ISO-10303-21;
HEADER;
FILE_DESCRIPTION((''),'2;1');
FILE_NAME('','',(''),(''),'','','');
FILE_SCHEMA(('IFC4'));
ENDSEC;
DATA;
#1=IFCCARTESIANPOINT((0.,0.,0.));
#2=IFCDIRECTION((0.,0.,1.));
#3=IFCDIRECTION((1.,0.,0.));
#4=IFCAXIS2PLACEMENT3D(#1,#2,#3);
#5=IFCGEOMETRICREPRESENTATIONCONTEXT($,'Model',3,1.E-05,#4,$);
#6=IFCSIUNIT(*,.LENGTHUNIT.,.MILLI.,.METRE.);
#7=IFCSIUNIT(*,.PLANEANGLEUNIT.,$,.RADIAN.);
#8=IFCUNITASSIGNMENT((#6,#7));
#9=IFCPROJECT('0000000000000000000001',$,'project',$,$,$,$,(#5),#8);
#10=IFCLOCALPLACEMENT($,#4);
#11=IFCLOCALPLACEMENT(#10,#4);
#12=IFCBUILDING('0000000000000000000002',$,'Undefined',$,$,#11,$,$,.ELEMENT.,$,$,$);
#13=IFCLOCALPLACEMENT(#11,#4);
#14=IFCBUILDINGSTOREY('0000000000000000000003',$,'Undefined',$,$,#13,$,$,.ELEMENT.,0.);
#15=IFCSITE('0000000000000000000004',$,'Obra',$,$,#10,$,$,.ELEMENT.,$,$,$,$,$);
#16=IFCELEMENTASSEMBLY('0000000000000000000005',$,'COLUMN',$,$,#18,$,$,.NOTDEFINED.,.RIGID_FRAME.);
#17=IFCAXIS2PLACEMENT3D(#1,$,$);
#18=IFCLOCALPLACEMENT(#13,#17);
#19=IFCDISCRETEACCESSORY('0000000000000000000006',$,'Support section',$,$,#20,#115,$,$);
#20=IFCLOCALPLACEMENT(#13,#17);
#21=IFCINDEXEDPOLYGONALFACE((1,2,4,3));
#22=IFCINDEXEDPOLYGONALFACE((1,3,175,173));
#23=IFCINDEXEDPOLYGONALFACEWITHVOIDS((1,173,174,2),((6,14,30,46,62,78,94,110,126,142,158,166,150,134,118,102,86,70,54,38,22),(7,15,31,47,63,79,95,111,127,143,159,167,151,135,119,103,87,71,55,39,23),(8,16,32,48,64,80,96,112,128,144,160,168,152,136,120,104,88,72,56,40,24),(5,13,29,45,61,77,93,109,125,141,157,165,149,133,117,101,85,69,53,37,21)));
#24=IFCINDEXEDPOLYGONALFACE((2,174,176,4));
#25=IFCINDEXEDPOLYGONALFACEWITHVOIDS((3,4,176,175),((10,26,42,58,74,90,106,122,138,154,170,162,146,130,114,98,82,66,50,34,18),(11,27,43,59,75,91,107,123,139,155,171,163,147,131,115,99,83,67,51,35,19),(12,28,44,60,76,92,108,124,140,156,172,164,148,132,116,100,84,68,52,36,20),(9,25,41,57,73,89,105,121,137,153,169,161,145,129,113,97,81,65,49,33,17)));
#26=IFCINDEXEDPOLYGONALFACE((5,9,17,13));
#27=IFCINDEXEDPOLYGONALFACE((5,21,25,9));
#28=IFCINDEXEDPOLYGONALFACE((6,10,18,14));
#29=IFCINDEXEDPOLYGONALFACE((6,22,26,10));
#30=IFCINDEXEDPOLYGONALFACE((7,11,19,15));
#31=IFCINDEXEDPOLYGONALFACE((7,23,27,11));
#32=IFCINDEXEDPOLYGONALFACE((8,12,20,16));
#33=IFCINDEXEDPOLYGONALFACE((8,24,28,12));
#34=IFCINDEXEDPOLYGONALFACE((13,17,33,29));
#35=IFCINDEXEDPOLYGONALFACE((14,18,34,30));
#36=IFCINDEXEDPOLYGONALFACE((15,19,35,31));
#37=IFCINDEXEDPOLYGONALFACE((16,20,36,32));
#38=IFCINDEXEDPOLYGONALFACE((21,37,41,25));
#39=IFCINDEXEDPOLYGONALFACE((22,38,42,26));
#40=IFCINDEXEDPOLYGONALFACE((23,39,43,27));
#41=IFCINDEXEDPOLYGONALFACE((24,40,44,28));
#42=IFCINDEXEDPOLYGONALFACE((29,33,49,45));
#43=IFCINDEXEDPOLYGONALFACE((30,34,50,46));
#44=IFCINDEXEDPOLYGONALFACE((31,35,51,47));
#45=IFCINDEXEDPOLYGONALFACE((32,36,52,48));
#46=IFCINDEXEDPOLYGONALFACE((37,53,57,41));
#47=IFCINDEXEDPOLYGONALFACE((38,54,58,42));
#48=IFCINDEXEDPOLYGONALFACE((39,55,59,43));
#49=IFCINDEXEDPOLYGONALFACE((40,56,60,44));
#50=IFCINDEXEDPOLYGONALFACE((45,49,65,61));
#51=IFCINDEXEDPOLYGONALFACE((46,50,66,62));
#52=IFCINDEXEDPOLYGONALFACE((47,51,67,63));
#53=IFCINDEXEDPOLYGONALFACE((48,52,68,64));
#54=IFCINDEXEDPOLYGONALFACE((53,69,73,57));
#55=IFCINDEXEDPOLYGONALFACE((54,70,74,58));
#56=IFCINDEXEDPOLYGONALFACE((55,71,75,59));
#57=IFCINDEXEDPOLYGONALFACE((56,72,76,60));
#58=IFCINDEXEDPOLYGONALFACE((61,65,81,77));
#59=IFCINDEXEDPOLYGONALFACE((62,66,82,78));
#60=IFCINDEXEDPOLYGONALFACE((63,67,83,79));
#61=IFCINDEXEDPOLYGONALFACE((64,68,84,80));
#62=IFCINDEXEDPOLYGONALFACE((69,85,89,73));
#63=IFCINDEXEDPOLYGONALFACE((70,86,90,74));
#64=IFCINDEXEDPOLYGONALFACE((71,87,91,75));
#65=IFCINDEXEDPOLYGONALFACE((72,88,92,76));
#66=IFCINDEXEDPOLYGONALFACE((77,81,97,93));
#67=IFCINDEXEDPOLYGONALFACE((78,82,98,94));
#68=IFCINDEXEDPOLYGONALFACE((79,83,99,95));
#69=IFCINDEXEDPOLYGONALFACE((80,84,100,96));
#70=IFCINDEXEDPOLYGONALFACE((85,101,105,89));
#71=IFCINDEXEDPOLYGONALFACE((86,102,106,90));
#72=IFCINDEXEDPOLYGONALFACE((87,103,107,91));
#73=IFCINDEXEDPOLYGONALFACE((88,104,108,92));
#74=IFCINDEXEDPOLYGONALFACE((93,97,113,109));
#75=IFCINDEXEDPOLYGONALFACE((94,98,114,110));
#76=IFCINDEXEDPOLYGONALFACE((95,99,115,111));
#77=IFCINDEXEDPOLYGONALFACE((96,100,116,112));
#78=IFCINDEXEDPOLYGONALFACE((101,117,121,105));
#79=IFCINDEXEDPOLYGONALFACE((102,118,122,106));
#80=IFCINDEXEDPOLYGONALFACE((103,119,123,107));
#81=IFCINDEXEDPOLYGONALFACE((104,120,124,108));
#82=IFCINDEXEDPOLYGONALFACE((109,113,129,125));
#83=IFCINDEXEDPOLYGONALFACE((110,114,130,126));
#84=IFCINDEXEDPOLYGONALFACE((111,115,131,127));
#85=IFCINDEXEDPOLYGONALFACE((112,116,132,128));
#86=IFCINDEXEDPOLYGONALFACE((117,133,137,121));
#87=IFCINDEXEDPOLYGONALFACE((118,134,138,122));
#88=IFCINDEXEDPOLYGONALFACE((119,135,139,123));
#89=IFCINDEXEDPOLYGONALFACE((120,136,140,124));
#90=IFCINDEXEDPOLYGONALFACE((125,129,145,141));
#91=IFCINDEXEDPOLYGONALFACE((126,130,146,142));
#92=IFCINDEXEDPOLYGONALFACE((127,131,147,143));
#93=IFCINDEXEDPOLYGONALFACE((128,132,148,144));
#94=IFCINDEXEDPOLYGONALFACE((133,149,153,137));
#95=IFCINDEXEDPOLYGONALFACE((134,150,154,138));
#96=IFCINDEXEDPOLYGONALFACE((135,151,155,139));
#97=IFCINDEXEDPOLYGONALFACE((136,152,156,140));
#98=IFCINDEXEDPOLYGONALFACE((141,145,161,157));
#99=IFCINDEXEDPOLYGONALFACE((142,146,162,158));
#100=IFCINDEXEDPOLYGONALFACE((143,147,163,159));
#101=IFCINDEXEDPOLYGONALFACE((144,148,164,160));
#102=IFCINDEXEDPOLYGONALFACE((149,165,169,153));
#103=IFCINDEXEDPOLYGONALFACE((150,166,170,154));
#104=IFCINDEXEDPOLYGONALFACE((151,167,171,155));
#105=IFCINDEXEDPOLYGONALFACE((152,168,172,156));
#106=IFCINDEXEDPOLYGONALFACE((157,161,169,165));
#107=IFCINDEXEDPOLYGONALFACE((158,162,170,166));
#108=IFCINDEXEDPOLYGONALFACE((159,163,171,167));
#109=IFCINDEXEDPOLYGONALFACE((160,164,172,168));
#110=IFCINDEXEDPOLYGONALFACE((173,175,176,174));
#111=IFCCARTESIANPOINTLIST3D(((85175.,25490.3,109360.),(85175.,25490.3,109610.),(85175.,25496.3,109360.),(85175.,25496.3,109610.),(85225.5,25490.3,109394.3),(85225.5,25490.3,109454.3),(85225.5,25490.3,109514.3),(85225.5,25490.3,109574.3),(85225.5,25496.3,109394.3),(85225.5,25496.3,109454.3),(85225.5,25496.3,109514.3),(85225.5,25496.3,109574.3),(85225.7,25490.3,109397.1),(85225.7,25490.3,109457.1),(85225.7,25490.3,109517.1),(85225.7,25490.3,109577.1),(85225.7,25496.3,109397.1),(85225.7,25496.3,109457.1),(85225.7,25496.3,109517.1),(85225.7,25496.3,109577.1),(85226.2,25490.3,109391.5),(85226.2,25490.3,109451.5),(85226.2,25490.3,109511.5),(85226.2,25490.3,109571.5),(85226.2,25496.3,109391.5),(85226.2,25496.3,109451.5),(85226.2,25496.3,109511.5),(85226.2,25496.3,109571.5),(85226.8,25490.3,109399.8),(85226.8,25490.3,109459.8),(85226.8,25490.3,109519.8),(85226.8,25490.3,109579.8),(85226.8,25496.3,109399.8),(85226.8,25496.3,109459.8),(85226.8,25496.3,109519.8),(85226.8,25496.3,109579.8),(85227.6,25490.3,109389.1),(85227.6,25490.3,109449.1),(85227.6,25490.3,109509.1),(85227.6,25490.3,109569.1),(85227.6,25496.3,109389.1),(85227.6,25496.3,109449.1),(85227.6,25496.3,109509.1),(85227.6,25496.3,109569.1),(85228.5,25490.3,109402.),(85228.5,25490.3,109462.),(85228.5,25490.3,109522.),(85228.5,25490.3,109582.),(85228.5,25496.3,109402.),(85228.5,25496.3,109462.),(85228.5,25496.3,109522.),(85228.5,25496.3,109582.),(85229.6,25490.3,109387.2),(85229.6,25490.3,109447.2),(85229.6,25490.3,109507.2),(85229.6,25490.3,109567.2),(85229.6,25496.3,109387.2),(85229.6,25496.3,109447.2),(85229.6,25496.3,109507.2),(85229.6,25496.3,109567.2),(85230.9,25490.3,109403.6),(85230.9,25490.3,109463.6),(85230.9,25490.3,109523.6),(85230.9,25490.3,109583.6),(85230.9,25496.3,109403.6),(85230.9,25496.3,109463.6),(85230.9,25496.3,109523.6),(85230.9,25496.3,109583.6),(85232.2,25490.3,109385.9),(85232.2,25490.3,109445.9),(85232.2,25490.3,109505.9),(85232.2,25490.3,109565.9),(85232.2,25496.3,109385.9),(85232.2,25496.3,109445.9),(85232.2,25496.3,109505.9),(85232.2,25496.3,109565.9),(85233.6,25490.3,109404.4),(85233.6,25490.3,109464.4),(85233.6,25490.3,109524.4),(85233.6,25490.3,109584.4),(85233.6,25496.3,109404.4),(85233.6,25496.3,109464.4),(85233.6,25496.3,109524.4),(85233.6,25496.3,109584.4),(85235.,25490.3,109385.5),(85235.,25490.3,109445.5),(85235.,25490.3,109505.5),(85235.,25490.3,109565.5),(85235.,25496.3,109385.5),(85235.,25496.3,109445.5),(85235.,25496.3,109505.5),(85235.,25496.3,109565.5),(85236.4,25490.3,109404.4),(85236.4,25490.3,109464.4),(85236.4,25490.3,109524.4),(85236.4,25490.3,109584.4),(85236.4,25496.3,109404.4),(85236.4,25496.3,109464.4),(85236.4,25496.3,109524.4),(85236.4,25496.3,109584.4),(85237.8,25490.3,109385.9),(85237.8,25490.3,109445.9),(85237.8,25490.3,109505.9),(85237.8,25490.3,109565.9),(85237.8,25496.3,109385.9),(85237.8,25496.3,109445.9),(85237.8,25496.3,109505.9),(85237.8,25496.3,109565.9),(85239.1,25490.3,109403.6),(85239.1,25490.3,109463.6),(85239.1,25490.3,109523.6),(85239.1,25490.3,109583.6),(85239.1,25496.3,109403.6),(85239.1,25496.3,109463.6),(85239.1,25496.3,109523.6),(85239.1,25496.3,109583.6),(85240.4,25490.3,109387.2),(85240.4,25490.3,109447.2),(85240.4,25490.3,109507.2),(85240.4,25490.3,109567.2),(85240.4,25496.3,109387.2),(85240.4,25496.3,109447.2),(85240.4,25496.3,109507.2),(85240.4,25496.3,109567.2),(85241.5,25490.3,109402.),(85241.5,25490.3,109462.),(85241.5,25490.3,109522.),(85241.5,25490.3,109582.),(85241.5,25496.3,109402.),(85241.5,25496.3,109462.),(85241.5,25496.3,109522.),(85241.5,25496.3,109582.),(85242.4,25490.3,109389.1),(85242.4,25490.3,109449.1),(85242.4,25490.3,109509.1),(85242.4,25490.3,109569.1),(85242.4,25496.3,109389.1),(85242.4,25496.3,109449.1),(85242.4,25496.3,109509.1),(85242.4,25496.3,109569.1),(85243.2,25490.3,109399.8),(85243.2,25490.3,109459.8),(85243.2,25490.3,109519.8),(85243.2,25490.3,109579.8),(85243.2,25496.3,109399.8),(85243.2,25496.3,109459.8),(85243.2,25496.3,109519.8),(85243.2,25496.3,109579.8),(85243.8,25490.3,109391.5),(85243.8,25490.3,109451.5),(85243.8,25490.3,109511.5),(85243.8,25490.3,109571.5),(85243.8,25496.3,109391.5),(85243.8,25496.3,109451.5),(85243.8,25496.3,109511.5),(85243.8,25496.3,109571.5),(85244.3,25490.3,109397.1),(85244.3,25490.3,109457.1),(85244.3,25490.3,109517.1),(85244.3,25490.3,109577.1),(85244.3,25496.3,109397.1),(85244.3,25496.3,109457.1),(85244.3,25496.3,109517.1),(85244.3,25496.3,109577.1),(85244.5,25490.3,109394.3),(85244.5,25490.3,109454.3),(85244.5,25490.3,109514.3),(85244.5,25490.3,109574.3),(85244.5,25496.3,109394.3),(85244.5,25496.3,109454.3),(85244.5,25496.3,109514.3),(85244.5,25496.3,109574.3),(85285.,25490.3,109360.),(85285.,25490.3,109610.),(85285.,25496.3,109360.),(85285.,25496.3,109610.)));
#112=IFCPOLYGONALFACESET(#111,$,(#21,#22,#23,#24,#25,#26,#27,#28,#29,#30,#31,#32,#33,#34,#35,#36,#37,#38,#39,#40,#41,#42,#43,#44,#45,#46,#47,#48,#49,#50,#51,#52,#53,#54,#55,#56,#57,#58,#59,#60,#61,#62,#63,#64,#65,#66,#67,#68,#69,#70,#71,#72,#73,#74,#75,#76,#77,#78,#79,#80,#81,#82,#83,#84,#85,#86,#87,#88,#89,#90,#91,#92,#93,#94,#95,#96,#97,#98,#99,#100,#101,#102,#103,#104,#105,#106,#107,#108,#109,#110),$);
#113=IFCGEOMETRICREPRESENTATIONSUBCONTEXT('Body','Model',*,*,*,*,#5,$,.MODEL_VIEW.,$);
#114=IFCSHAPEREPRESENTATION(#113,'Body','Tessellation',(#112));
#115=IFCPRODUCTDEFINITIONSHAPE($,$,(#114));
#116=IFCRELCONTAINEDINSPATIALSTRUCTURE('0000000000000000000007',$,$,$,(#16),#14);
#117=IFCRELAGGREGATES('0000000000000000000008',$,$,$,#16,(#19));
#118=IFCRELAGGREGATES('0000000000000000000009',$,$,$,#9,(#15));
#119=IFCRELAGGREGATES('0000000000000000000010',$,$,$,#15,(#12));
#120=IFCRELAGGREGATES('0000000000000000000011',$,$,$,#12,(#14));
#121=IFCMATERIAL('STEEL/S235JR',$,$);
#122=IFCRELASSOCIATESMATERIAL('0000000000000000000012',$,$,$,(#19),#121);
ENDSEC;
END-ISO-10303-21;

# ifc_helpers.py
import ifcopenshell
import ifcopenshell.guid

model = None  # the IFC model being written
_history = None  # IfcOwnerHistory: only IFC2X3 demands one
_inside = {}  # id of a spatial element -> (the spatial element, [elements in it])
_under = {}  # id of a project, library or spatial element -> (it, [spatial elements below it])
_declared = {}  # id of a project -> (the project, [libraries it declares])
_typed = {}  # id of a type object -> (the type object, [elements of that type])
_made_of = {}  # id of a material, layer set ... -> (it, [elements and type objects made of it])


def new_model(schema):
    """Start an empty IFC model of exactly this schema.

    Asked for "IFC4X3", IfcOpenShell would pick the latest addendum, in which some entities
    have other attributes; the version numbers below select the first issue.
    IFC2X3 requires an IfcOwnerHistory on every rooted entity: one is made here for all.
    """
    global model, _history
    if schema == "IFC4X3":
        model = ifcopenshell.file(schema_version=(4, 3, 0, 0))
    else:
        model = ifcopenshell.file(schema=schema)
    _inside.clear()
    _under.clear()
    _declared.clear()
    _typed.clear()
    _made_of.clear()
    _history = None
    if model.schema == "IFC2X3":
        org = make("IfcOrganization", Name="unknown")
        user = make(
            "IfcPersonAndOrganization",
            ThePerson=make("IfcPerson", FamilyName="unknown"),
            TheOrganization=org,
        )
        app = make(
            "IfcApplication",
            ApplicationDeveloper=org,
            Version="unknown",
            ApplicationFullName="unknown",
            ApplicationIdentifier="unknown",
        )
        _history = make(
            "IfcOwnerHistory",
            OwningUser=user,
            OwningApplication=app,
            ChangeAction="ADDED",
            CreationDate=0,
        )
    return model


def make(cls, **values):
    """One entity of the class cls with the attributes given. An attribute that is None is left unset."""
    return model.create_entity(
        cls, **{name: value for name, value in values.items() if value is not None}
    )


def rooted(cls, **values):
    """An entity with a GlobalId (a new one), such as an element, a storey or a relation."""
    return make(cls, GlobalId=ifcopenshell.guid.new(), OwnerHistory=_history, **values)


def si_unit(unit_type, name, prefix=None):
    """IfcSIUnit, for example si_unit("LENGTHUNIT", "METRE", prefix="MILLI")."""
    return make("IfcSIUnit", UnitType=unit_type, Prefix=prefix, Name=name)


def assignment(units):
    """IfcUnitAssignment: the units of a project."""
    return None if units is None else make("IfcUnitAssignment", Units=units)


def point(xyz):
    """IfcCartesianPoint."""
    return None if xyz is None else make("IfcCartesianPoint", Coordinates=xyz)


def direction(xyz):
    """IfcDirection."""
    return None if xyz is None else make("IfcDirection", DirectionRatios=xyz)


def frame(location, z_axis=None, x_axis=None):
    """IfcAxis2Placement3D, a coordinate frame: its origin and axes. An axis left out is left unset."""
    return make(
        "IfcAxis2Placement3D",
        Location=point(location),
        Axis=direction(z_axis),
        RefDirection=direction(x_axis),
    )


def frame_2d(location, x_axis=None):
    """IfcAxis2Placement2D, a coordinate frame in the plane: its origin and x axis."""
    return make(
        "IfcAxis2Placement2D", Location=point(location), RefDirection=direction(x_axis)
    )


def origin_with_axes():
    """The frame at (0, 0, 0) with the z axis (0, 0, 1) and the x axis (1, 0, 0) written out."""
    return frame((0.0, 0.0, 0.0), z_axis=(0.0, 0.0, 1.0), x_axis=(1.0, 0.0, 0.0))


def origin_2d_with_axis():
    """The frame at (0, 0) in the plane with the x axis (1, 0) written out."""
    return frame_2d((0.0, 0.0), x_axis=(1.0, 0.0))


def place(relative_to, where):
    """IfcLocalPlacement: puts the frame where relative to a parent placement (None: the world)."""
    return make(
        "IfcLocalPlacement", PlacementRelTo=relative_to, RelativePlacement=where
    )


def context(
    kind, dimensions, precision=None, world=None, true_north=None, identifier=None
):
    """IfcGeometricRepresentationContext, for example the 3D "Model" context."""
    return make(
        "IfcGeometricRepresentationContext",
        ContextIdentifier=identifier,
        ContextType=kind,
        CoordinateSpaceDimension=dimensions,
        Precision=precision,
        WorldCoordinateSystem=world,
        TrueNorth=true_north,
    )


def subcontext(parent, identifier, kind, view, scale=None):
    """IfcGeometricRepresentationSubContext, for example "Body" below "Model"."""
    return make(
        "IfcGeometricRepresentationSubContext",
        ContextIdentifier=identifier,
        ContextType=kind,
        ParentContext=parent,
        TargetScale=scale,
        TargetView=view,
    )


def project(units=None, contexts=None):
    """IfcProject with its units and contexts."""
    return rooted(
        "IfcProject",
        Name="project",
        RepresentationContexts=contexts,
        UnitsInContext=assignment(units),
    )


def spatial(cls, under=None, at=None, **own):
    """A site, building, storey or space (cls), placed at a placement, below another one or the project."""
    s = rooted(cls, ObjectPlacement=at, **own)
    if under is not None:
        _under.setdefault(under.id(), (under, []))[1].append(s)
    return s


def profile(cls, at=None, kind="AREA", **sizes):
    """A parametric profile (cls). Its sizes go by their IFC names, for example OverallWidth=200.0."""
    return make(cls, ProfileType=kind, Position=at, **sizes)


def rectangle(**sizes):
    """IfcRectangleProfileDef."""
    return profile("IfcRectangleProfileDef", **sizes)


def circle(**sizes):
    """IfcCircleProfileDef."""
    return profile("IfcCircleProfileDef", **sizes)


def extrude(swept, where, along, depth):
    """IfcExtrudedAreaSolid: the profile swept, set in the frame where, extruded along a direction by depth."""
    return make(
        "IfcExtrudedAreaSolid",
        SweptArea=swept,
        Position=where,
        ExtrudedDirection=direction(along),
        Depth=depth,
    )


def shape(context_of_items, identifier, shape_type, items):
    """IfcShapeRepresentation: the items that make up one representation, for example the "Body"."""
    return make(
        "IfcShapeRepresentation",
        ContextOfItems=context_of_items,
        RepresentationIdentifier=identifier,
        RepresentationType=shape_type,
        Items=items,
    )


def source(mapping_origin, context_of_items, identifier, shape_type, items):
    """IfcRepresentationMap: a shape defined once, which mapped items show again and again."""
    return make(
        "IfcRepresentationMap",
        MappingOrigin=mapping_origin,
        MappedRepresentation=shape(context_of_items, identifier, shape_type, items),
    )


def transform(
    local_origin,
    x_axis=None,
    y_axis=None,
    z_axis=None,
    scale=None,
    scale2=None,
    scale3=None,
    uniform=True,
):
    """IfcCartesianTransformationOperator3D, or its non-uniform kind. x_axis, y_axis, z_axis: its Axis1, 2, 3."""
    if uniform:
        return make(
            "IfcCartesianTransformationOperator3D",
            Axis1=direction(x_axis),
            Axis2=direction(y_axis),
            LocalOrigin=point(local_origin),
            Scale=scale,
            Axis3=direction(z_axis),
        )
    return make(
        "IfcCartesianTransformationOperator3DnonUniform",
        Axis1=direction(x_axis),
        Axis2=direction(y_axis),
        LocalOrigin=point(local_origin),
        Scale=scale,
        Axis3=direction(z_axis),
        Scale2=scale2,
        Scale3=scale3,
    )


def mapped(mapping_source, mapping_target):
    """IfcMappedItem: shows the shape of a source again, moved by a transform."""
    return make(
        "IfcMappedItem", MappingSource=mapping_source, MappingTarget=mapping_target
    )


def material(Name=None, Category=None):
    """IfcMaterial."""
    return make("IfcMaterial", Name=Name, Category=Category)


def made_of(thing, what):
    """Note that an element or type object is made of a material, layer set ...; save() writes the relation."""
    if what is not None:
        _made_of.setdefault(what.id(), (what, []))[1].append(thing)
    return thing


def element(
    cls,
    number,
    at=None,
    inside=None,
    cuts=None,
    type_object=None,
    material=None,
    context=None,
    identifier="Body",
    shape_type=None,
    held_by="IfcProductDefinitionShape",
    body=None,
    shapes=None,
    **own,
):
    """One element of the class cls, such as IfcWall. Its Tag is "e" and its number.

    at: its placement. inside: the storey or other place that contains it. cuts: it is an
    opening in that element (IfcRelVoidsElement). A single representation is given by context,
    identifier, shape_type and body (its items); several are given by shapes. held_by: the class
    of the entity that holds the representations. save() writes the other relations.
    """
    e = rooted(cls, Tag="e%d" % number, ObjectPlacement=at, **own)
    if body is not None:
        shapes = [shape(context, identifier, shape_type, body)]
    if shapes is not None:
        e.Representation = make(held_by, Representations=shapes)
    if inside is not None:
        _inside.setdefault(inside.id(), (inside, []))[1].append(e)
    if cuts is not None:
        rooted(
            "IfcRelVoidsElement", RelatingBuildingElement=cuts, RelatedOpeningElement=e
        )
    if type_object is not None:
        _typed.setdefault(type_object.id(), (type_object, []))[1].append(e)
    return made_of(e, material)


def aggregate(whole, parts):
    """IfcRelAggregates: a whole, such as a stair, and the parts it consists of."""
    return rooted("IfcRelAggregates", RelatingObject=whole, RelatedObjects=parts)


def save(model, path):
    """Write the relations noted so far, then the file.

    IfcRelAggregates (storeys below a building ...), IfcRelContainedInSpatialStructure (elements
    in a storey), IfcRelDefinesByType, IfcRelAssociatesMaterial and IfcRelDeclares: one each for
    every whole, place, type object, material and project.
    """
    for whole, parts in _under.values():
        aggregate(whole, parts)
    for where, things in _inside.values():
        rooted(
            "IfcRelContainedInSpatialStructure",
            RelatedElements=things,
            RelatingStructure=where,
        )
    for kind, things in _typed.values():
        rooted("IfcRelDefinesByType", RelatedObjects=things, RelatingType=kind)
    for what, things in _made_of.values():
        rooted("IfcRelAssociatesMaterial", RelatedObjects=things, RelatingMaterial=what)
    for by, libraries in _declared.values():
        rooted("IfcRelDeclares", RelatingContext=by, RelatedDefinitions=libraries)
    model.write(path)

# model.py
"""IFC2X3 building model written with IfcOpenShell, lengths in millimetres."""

from ifc_helpers import new_model, si_unit, frame, origin_with_axes, origin_2d_with_axis, place, context, subcontext, project, spatial, rectangle, circle, extrude, source, transform, mapped, material, element, aggregate, save


model = new_model("IFC2X3")

# Units and contexts
model_context = context("Model", 3, precision=1e-05, world=origin_with_axes())
body_context = subcontext(model_context, "Body", "Model", "MODEL_VIEW")
ifc_project = project(units=[si_unit("LENGTHUNIT", "METRE", prefix="MILLI"), si_unit("PLANEANGLEUNIT", "RADIAN")], contexts=[model_context])

# Site, building, storey
site_placement = place(None, origin_with_axes())
site = spatial("IfcSite", under=ifc_project, at=site_placement, Name="Obra", CompositionType="ELEMENT")
building_placement = place(site_placement, origin_with_axes())
building = spatial("IfcBuilding", under=site, at=building_placement, Name="Undefined", CompositionType="ELEMENT")
storey_placement = place(building_placement, origin_with_axes())
storey = spatial("IfcBuildingStorey", under=building, at=storey_placement, Name="Undefined", CompositionType="ELEMENT", Elevation=0.0)

# Shared definitions
ifc_material_1 = material(Name="STEEL/S235JR")

# Element assembly, discrete accessory, opening
assembly_1_placement = place(storey_placement, origin_with_axes())
assembly_1 = element("IfcElementAssembly", 1, at=assembly_1_placement, inside=storey, Name="COLUMN", AssemblyPlace="NOTDEFINED", PredefinedType="RIGID_FRAME")
shared_shape_1 = source(origin_with_axes(), body_context, "Body", "SweptSolid", [
    extrude(circle(Radius=9.5, at=origin_2d_with_axis()), frame((0.0, -9.8, 0.0), z_axis=(0.0, 1.0, 0.0), x_axis=(1.0, 0.0, 0.0)), (0.0, 0.0, 1.0), 6.2),
])
discrete_accessory_1_placement = place(assembly_1_placement, frame((85230.0, 25493.3, 109360.0), z_axis=(0.0, 0.0, 1.0), x_axis=(-1.0, 0.0, 0.0)))
discrete_accessory_1 = element("IfcDiscreteAccessory", 2, at=discrete_accessory_1_placement, material=ifc_material_1, Name="Support section", context=body_context, shape_type="SweptSolid", body=[
    extrude(rectangle(XDim=6.0, YDim=110.0, at=origin_2d_with_axis()), frame((0.0, 0.0, 250.0), z_axis=(0.0, 0.0, -1.0), x_axis=(0.0, 1.0, 0.0)), (0.0, 0.0, 1.0), 250.0),
])
opening_1_placement = place(assembly_1_placement, frame((85185.0, 25500.0, 109650.0), z_axis=(1.0, 0.0, 0.0), x_axis=(0.0, 0.0, -1.0)))
element("IfcOpeningElement", 3, at=opening_1_placement, cuts=discrete_accessory_1, ObjectType="Opening", context=body_context, shape_type="MappedRepresentation", body=[
    mapped(shared_shape_1, transform((75.0, 0.0, 50.0))),
    mapped(shared_shape_1, transform((135.0, 0.0, 50.0))),
    mapped(shared_shape_1, transform((195.0, 0.0, 50.0))),
    mapped(shared_shape_1, transform((255.0, 0.0, 50.0))),
])
aggregate(assembly_1, [discrete_accessory_1])

save(model, "model.ifc")
